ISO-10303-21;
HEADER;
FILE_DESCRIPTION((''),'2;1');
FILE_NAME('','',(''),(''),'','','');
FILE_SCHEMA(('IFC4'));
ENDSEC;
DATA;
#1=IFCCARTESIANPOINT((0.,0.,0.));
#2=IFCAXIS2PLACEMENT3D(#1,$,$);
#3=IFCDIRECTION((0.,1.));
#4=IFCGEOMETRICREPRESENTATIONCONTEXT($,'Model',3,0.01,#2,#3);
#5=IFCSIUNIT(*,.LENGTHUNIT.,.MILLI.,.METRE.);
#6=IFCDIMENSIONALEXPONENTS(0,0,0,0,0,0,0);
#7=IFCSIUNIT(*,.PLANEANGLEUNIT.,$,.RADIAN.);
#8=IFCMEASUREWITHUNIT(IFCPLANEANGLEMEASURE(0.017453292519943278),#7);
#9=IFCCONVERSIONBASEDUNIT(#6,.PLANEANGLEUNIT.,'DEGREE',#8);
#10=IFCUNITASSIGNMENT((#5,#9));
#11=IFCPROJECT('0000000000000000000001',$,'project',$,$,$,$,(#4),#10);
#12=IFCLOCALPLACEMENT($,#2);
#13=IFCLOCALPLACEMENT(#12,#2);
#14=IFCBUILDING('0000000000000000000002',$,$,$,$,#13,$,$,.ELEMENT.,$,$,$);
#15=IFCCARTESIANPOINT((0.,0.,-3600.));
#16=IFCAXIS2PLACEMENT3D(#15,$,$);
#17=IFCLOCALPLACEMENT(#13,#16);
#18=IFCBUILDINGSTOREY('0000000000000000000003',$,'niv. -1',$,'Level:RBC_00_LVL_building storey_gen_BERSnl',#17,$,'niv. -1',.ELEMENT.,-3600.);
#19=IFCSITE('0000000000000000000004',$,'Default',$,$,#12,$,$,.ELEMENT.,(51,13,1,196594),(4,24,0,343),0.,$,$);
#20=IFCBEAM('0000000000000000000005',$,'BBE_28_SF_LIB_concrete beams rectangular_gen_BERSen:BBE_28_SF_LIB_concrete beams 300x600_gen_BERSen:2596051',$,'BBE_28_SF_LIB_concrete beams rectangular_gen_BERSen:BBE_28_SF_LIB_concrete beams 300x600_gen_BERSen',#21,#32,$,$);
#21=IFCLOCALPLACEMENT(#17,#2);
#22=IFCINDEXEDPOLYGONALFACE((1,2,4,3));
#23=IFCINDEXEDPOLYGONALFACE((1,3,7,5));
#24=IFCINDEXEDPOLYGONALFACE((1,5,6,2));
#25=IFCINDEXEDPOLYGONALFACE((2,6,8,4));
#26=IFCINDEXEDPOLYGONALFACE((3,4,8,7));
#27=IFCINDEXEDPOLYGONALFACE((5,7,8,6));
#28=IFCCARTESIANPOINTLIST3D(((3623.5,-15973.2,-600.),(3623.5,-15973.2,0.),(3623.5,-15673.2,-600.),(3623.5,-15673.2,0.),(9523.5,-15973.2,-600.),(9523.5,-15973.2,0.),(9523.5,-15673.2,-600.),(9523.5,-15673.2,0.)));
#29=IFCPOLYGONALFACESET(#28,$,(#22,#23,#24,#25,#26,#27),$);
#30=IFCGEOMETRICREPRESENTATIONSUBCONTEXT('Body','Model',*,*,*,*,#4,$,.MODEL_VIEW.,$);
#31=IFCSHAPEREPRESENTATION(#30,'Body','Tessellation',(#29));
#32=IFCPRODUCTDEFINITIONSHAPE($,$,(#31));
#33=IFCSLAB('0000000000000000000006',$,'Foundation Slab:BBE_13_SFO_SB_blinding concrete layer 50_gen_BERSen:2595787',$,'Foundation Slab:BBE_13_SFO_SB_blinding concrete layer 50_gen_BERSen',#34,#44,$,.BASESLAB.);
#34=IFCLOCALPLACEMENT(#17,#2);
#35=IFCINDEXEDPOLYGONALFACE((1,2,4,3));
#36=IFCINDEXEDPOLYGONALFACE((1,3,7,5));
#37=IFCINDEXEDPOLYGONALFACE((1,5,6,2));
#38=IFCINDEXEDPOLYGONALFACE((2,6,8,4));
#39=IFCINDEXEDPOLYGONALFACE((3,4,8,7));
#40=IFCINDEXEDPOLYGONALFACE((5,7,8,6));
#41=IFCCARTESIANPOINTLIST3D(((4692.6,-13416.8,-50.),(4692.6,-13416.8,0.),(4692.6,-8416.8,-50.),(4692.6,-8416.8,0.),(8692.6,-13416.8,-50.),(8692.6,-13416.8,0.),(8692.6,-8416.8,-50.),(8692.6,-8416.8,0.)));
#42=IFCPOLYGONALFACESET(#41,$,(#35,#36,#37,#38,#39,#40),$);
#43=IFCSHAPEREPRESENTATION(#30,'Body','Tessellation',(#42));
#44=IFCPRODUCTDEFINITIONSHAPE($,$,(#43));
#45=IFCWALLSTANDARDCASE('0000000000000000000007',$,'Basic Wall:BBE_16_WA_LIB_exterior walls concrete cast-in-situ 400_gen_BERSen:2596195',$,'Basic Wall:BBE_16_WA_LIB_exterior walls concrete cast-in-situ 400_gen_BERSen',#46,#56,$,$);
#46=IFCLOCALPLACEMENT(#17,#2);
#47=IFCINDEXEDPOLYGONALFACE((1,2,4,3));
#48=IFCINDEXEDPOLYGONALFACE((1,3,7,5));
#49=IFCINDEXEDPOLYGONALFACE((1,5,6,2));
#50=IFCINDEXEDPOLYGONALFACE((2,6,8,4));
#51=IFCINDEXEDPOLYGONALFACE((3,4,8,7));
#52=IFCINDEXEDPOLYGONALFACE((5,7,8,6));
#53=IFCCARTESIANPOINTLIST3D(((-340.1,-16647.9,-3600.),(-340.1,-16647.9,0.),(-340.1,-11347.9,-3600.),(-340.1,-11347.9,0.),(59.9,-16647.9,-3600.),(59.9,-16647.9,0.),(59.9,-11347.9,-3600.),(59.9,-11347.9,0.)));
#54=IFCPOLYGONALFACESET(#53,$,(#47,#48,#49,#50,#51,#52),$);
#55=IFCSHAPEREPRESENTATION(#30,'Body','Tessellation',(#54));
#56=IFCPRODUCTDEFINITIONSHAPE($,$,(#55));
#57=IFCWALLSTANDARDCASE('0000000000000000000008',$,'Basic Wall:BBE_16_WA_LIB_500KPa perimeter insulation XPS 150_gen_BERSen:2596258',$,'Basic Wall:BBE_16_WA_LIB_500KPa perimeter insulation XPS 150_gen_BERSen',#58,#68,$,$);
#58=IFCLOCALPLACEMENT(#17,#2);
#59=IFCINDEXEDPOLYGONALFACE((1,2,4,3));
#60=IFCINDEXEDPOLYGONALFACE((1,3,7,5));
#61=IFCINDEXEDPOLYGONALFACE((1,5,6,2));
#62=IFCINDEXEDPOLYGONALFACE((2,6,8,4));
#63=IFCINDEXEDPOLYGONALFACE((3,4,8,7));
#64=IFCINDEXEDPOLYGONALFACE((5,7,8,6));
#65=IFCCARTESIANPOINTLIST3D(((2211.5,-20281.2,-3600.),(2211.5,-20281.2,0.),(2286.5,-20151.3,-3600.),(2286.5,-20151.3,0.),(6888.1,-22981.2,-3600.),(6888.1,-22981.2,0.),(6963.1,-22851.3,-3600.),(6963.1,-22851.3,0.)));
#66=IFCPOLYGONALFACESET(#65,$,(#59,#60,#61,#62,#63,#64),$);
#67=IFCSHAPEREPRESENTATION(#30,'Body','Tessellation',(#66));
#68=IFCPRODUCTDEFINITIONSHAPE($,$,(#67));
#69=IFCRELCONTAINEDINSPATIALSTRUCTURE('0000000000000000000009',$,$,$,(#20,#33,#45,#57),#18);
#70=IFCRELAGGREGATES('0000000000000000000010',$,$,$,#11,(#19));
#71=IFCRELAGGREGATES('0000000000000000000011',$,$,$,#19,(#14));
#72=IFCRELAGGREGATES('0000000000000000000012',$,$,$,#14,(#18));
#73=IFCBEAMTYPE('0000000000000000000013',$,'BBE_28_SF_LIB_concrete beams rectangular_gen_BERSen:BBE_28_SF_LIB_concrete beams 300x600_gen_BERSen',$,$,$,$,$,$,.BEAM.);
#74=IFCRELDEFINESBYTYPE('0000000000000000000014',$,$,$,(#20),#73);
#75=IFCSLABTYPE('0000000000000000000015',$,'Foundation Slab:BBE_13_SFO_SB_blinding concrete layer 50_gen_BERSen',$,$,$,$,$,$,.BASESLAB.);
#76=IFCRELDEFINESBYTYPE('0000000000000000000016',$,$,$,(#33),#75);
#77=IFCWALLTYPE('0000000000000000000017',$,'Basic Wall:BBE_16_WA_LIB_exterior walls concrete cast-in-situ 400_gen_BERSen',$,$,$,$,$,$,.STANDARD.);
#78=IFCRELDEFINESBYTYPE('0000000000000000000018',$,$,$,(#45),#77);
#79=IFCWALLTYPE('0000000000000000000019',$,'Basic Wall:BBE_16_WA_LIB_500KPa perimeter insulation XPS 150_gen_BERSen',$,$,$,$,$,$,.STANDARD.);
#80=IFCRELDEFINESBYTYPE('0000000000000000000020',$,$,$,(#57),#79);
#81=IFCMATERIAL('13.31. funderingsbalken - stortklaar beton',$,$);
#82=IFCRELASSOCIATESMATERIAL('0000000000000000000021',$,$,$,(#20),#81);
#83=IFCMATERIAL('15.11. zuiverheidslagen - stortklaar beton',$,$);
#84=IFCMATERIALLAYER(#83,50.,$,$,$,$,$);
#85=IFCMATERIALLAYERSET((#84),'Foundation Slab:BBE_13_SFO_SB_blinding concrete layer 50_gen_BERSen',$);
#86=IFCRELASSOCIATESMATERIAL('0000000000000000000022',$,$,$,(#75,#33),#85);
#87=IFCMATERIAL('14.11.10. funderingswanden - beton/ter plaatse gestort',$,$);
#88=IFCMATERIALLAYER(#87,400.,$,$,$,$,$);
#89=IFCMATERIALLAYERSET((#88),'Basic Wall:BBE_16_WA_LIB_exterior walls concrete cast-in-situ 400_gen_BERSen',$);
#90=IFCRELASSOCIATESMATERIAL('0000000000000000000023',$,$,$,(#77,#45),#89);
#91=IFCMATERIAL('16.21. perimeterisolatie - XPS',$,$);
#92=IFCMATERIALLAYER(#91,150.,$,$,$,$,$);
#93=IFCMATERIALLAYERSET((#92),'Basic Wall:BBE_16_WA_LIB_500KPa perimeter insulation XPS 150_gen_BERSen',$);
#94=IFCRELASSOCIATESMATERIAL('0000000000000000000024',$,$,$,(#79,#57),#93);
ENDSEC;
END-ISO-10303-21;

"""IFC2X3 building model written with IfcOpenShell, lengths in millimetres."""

from ifc_helpers import new_model, entity, si_unit, converted_unit, direction, frame, frame_2d, origin, place, context, subcontext, project, spatial, rectangle, extrude, material, layer, layer_set, layer_usage, type_object, element, save


model = new_model("IFC2X3")

# Units and contexts
model_context = context("Model", 3, precision=0.01, world=origin(), true_north=direction((0.0, 1.0)))
body_context = subcontext(model_context, "Body", "Model", "MODEL_VIEW")
ifc_project = project(units=[si_unit("LENGTHUNIT", "METRE", prefix="MILLI"), converted_unit("PLANEANGLEUNIT", "DEGREE", entity("IfcPlaneAngleMeasure", 0.017453292519943278), si_unit("PLANEANGLEUNIT", "RADIAN"), dimensions=[0, 0, 0, 0, 0, 0, 0])], contexts=[model_context])

# Site, building, storey
site_placement = place(None, origin())
site = spatial("IfcSite", under=ifc_project, at=site_placement, Name="Default", CompositionType="ELEMENT", RefLatitude=(51, 13, 1, 196594), RefLongitude=(4, 24, 0, 343), RefElevation=0.0)
building_placement = place(site_placement, origin())
building = spatial("IfcBuilding", under=site, at=building_placement, CompositionType="ELEMENT")
storey_placement = place(building_placement, frame((0.0, 0.0, -3600.0)))
storey = spatial("IfcBuildingStorey", under=building, at=storey_placement, Name="niv. -1", ObjectType="Level:RBC_00_LVL_building storey_gen_BERSnl", LongName="niv. -1", CompositionType="ELEMENT", Elevation=-3600.0)

# Beam
ifc_material_1 = material(Name="13.31. funderingsbalken - stortklaar beton")
beam_type = type_object("IfcBeamType", Name="BBE_28_SF_LIB_concrete beams rectangular_gen_BERSen:BBE_28_SF_LIB_concrete beams 300x600_gen_BERSen", PredefinedType="BEAM")
beam_placement = place(storey_placement, frame((3623.5, -15823.2, 0.0)))
element("IfcBeam", 1, at=beam_placement, inside=storey, type_object=beam_type, material=ifc_material_1, Name="BBE_28_SF_LIB_concrete beams rectangular_gen_BERSen:BBE_28_SF_LIB_concrete beams 300x600_gen_BERSen:2596051", ObjectType="BBE_28_SF_LIB_concrete beams rectangular_gen_BERSen:BBE_28_SF_LIB_concrete beams 300x600_gen_BERSen", context=body_context, shape_type="SweptSolid", body=[
    extrude(rectangle(XDim=600.0, YDim=300.0, at=frame_2d((0.0, 0.0), x_axis=(1.0, 0.0))), frame((0.0, 0.0, -300.0), z_axis=(1.0, 0.0, 0.0), x_axis=(0.0, 0.0, -1.0)), (0.0, 0.0, 1.0), 5900.0),
])

# Slab
ifc_material_2 = material(Name="15.11. zuiverheidslagen - stortklaar beton")
ifc_layer_1 = layer(ifc_material_2, 50.0)
ifc_layer_set_1 = layer_set([ifc_layer_1], Name="Foundation Slab:BBE_13_SFO_SB_blinding concrete layer 50_gen_BERSen")
ifc_layer_usage_1 = layer_usage(ifc_layer_set_1, "AXIS3", "POSITIVE", 0.0)
slab_type = type_object("IfcSlabType", Name="Foundation Slab:BBE_13_SFO_SB_blinding concrete layer 50_gen_BERSen", PredefinedType="BASESLAB", material=ifc_layer_set_1)
slab_placement = place(storey_placement, origin())
element("IfcSlab", 2, at=slab_placement, inside=storey, type_object=slab_type, material=ifc_layer_usage_1, Name="Foundation Slab:BBE_13_SFO_SB_blinding concrete layer 50_gen_BERSen:2595787", ObjectType="Foundation Slab:BBE_13_SFO_SB_blinding concrete layer 50_gen_BERSen", PredefinedType="BASESLAB", context=body_context, shape_type="SweptSolid", body=[
    extrude(rectangle(XDim=5000.0, YDim=4000.0, at=frame_2d((0.0, 0.0), x_axis=(1.0, 0.0))), frame((6692.6, -10916.8, 0.0), z_axis=(0.0, 0.0, -1.0), x_axis=(0.0, 1.0, 0.0)), (0.0, 0.0, 1.0), 50.0),
])

# Walls
ifc_material_3 = material(Name="14.11.10. funderingswanden - beton/ter plaatse gestort")
ifc_layer_2 = layer(ifc_material_3, 400.0)
ifc_layer_set_2 = layer_set([ifc_layer_2], Name="Basic Wall:BBE_16_WA_LIB_exterior walls concrete cast-in-situ 400_gen_BERSen")
ifc_layer_usage_2 = layer_usage(ifc_layer_set_2, "AXIS2", "NEGATIVE", 200.0)
wall_type_1 = type_object("IfcWallType", Name="Basic Wall:BBE_16_WA_LIB_exterior walls concrete cast-in-situ 400_gen_BERSen", PredefinedType="STANDARD", material=ifc_layer_set_2)
wall_1_placement = place(storey_placement, frame((-140.1, -11347.9, -3600.0), z_axis=(0.0, 0.0, 1.0), x_axis=(0.0, -1.0, 0.0)))
element("IfcWallStandardCase", 3, at=wall_1_placement, inside=storey, type_object=wall_type_1, material=ifc_layer_usage_2, Name="Basic Wall:BBE_16_WA_LIB_exterior walls concrete cast-in-situ 400_gen_BERSen:2596195", ObjectType="Basic Wall:BBE_16_WA_LIB_exterior walls concrete cast-in-situ 400_gen_BERSen", context=body_context, shape_type="SweptSolid", body=[
    extrude(rectangle(XDim=5300.0, YDim=400.0, at=frame_2d((2650.0, 0.0), x_axis=(-1.0, 0.0))), origin(), (0.0, 0.0, 1.0), 3600.0),
])
ifc_material_4 = material(Name="16.21. perimeterisolatie - XPS")
ifc_layer_3 = layer(ifc_material_4, 150.0)
ifc_layer_set_3 = layer_set([ifc_layer_3], Name="Basic Wall:BBE_16_WA_LIB_500KPa perimeter insulation XPS 150_gen_BERSen")
ifc_layer_usage_3 = layer_usage(ifc_layer_set_3, "AXIS2", "NEGATIVE", 75.0)
wall_type_2 = type_object("IfcWallType", Name="Basic Wall:BBE_16_WA_LIB_500KPa perimeter insulation XPS 150_gen_BERSen", PredefinedType="STANDARD", material=ifc_layer_set_3)
wall_2_placement = place(storey_placement, frame((2249.0, -20216.3, -3600.0), z_axis=(0.0, 0.0, 1.0), x_axis=(0.866025, -0.5, 0.0)))
element("IfcWallStandardCase", 4, at=wall_2_placement, inside=storey, type_object=wall_type_2, material=ifc_layer_usage_3, Name="Basic Wall:BBE_16_WA_LIB_500KPa perimeter insulation XPS 150_gen_BERSen:2596258", ObjectType="Basic Wall:BBE_16_WA_LIB_500KPa perimeter insulation XPS 150_gen_BERSen", context=body_context, shape_type="SweptSolid", body=[
    extrude(rectangle(XDim=5400.0, YDim=150.0, at=frame_2d((2700.0, 0.0), x_axis=(-1.0, 0.0))), origin(), (0.0, 0.0, 1.0), 3600.0),
])

save(model, "model.ifc")
